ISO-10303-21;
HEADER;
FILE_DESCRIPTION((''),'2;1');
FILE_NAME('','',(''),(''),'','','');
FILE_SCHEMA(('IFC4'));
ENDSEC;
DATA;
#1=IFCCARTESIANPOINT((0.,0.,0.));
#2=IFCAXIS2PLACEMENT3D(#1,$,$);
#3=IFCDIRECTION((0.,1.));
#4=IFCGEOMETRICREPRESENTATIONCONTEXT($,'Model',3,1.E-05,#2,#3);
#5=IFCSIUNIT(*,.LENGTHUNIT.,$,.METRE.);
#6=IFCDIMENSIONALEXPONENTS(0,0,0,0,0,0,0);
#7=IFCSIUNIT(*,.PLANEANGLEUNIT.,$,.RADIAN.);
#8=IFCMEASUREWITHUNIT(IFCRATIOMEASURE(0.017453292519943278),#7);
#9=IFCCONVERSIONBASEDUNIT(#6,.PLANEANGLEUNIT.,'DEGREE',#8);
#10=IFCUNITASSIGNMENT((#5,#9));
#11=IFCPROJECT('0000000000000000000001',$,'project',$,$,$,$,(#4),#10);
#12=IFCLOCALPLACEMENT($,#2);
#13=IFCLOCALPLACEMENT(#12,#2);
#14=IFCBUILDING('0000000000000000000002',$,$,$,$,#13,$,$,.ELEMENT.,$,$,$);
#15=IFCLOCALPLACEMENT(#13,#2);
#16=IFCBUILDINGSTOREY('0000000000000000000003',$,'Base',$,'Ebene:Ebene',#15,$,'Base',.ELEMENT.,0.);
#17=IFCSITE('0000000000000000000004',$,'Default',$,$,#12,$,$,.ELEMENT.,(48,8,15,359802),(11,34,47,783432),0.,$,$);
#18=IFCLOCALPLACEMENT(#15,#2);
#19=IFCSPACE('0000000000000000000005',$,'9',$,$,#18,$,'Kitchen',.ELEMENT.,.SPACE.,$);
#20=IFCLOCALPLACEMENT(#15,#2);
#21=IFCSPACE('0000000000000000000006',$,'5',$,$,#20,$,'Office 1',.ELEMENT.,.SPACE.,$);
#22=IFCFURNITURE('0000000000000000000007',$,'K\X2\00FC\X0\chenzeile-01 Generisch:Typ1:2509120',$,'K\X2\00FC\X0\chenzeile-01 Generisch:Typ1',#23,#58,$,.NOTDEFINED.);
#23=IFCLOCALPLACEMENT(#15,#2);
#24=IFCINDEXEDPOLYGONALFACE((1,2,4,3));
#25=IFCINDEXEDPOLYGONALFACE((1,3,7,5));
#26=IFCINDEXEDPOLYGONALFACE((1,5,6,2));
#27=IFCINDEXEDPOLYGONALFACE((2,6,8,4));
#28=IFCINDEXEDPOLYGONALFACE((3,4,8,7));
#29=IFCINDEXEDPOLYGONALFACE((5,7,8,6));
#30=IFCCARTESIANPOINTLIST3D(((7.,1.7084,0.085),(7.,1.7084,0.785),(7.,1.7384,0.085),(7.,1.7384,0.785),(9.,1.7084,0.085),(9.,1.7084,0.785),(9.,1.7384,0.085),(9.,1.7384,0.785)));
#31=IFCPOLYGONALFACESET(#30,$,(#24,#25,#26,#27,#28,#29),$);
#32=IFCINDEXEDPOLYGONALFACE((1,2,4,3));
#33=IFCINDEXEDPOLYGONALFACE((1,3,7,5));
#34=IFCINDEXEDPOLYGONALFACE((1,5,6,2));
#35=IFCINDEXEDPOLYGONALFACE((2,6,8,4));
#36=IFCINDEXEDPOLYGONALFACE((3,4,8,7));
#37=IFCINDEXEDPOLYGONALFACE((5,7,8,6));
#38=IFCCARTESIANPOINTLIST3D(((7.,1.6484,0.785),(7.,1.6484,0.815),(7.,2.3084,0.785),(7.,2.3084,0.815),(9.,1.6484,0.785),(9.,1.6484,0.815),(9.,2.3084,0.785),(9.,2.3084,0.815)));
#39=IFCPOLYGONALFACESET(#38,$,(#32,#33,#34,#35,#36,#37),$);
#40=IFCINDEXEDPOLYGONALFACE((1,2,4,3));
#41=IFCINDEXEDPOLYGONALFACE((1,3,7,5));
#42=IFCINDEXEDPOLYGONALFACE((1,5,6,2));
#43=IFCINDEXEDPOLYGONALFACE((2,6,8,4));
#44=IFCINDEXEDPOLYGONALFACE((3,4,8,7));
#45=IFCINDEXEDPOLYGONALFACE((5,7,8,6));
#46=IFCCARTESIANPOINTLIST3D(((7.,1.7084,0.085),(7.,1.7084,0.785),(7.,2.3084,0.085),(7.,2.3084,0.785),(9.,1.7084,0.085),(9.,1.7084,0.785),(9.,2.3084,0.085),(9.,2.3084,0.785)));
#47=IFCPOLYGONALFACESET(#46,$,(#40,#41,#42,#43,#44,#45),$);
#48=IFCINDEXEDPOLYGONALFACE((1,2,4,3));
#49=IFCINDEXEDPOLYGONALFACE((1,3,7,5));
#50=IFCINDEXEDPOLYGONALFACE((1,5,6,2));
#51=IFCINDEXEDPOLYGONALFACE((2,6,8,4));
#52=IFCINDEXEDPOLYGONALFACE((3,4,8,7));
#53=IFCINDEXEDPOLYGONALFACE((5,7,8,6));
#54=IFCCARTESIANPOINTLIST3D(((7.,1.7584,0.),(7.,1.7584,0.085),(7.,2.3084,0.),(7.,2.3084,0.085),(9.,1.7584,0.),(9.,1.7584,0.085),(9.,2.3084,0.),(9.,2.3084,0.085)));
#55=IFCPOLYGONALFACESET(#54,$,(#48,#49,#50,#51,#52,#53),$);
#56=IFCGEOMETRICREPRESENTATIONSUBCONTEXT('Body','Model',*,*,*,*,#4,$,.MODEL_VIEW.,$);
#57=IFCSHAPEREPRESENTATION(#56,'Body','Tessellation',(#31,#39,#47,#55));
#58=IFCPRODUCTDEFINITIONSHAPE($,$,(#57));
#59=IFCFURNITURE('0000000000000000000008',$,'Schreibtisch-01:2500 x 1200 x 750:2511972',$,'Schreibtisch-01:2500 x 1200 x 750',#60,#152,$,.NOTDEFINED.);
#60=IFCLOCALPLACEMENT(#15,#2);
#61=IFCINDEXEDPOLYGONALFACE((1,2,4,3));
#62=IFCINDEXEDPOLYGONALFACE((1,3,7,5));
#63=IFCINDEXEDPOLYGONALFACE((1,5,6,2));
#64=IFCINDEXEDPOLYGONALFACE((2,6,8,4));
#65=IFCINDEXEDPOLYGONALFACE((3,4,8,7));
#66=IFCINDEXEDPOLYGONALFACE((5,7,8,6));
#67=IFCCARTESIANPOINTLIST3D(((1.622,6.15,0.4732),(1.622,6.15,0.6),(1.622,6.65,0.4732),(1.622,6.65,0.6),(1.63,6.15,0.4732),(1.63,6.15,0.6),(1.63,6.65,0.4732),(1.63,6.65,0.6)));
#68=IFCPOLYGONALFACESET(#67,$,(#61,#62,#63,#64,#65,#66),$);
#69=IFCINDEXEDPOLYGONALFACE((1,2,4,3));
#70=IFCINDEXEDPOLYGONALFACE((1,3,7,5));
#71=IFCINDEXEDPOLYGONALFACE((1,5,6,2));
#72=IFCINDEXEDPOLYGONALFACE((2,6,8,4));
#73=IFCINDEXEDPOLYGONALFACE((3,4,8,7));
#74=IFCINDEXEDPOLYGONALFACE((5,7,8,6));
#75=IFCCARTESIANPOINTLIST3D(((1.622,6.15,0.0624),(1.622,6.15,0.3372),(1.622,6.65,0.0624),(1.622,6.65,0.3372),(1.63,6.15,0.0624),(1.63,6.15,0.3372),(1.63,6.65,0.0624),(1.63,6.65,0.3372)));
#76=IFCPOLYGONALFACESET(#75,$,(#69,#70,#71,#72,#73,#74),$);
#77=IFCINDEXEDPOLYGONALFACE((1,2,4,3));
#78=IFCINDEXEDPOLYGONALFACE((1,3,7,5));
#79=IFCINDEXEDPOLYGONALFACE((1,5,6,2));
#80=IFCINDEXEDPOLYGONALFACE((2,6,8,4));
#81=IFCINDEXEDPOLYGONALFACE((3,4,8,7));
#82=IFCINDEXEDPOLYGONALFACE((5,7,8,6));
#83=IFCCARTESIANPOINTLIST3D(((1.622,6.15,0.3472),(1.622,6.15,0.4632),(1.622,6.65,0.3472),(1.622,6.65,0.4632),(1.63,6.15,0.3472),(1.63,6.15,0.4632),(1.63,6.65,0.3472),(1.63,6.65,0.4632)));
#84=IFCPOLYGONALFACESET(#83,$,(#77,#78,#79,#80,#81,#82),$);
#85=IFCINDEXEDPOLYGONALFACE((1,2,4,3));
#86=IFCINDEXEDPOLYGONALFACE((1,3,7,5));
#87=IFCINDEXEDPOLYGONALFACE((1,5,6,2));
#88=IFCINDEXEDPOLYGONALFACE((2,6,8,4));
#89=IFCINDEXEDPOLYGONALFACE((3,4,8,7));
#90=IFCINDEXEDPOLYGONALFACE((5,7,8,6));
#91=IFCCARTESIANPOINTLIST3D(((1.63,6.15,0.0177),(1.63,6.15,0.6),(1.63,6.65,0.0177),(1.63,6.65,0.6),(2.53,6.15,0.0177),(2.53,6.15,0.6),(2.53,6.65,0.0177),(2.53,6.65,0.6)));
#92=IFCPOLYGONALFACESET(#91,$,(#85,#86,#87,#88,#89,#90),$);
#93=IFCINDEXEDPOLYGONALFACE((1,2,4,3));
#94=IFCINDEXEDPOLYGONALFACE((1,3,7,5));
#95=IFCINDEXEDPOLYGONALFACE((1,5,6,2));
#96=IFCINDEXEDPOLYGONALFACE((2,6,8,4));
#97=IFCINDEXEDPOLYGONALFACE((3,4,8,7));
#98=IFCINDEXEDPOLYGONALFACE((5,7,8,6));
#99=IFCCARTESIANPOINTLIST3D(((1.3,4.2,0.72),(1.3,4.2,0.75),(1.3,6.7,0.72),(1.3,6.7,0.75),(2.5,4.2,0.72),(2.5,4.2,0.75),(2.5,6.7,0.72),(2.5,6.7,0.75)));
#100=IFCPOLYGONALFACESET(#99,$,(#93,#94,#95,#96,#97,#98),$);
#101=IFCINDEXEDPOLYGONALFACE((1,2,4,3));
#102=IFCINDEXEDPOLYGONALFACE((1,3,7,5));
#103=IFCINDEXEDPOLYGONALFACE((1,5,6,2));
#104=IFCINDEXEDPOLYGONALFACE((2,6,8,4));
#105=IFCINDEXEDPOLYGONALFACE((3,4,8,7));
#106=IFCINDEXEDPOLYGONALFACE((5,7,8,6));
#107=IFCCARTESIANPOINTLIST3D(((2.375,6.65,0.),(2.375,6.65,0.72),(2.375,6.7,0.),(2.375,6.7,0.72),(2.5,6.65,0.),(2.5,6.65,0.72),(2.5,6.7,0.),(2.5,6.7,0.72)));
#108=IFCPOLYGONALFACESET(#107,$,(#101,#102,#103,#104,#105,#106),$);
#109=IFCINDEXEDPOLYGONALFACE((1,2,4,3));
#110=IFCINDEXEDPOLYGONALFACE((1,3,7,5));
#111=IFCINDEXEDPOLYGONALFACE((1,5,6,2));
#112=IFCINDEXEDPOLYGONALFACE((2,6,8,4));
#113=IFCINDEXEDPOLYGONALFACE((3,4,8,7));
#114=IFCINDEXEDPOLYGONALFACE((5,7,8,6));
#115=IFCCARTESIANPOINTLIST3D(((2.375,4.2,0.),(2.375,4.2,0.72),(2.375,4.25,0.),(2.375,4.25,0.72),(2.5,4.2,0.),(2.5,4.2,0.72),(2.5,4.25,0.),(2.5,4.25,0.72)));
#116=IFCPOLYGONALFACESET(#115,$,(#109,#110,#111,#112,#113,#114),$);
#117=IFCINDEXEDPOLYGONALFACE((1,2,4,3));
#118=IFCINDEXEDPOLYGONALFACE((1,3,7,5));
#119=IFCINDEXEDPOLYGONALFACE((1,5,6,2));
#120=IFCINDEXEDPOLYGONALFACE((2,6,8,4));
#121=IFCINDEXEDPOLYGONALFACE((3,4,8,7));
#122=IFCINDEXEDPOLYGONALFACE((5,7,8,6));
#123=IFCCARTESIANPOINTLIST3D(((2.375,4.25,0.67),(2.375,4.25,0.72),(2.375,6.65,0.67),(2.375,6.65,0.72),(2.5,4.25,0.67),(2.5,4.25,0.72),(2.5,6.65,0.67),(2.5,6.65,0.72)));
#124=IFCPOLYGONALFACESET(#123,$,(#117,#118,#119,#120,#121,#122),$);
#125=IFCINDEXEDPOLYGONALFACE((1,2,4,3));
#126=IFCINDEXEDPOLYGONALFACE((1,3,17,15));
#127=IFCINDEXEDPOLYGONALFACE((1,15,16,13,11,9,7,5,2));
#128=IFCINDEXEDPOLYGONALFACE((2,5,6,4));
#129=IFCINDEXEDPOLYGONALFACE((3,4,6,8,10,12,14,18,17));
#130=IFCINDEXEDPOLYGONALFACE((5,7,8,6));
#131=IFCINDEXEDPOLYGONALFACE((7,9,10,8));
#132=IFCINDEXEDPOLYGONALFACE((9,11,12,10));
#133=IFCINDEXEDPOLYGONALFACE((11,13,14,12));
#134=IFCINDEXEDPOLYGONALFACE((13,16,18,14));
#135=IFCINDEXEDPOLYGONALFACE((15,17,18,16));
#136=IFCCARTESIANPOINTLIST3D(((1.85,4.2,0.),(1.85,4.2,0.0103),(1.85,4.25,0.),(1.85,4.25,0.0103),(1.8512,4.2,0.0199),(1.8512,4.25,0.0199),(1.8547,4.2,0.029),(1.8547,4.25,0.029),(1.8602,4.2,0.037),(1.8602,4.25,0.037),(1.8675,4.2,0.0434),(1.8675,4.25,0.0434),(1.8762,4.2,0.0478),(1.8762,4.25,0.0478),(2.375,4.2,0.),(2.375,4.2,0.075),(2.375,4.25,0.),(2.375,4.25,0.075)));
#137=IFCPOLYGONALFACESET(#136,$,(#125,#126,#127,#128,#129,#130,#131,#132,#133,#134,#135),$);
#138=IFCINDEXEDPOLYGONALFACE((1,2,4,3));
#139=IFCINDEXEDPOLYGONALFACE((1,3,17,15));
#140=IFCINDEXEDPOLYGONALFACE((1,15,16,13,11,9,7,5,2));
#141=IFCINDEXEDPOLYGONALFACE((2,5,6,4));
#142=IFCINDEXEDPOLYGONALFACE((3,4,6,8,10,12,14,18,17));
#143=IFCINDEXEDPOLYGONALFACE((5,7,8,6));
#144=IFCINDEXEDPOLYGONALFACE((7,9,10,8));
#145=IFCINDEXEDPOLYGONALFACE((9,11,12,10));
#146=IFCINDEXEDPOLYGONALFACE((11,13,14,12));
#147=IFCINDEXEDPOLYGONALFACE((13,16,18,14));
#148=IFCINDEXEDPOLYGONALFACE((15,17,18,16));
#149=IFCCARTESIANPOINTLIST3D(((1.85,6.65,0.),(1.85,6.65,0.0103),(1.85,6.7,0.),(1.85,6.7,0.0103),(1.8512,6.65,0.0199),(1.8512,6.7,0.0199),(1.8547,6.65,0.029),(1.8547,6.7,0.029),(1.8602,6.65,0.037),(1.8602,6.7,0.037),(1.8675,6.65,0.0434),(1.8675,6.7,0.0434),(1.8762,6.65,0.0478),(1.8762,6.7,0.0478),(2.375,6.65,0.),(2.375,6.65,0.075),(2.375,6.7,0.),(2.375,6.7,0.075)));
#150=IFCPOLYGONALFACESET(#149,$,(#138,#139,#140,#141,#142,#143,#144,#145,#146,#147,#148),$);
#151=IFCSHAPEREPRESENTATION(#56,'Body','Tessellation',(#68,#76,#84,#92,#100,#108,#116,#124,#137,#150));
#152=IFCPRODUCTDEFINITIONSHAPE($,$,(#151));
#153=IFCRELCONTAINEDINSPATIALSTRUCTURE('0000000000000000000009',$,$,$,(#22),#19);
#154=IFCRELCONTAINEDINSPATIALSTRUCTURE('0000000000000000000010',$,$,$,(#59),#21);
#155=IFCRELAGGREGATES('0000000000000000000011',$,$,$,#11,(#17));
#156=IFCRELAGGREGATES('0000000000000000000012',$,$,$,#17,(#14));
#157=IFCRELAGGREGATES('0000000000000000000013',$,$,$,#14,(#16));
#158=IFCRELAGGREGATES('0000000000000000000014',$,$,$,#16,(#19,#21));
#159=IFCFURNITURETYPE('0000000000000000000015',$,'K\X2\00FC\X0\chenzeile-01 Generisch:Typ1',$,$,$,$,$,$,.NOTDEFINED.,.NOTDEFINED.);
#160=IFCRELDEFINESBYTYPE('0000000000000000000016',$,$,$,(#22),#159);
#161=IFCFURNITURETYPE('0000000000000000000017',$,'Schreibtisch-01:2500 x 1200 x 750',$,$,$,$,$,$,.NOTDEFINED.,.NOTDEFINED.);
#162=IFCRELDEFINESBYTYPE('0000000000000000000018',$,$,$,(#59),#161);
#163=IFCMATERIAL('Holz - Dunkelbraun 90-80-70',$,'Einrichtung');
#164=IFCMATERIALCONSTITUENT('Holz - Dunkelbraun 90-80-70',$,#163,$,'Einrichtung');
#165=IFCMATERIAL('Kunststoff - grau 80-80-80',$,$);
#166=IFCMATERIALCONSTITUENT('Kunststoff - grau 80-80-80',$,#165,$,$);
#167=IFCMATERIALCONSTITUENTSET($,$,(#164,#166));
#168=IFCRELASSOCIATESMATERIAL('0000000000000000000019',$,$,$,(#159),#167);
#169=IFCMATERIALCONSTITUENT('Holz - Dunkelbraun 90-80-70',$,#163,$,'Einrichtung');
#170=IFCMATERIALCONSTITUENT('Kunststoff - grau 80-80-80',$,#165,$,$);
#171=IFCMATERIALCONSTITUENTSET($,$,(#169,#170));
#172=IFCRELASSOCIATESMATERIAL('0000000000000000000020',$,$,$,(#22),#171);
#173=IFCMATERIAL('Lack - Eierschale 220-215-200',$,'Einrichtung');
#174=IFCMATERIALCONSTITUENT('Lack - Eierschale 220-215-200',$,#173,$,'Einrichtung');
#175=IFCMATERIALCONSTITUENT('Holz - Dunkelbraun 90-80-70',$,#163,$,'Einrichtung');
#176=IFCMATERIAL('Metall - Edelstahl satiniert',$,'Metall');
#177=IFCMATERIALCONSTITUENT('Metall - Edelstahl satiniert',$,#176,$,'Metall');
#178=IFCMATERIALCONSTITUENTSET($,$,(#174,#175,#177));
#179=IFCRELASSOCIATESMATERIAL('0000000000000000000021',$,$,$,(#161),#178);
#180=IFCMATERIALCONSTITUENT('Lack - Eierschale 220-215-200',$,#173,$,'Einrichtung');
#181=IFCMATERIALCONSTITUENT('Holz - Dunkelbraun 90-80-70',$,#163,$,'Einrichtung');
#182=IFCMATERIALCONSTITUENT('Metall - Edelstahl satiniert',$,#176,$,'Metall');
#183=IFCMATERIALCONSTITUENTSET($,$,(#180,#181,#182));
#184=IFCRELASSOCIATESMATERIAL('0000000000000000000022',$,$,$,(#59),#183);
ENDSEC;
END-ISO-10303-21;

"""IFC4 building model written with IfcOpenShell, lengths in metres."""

from ifc_helpers import new_model, entity, si_unit, converted_unit, direction, frame, origin, place, context, subcontext, project, spatial, line, arc, indexed_curve, outline, extrude, source, transform, mapped, material, constituent, constituent_set, type_object, type_shapes, element, save


model = new_model("IFC4")

# Units and contexts
model_context = context("Model", 3, precision=1e-05, world=origin(), true_north=direction((0.0, 1.0)))
body_context = subcontext(model_context, "Body", "Model", "MODEL_VIEW")
ifc_project = project(units=[si_unit("LENGTHUNIT", "METRE"), converted_unit("PLANEANGLEUNIT", "DEGREE", entity("IfcRatioMeasure", 0.017453292519943278), si_unit("PLANEANGLEUNIT", "RADIAN"), dimensions=[0, 0, 0, 0, 0, 0, 0])], contexts=[model_context])

# Site, building, storey, space
site_placement = place(None, origin())
site = spatial("IfcSite", under=ifc_project, at=site_placement, Name="Default", CompositionType="ELEMENT", RefLatitude=(48, 8, 15, 359802), RefLongitude=(11, 34, 47, 783432), RefElevation=0.0)
building_placement = place(site_placement, origin())
building = spatial("IfcBuilding", under=site, at=building_placement, CompositionType="ELEMENT")
storey_placement = place(building_placement, origin())
storey = spatial("IfcBuildingStorey", under=building, at=storey_placement, Name="Base", ObjectType="Ebene:Ebene", LongName="Base", CompositionType="ELEMENT", Elevation=0.0)
space_1_placement = place(storey_placement, origin())
space_1 = spatial("IfcSpace", under=storey, at=space_1_placement, Name="9", LongName="Kitchen", CompositionType="ELEMENT", PredefinedType="SPACE")

# Furniture
ifc_material_1 = material(Name="Holz - Dunkelbraun 90-80-70", Category="Einrichtung")
ifc_constituent_1 = constituent(ifc_material_1, Name="Holz - Dunkelbraun 90-80-70", Category="Einrichtung")
ifc_material_2 = material(Name="Kunststoff - grau 80-80-80")
ifc_constituent_2 = constituent(ifc_material_2, Name="Kunststoff - grau 80-80-80")
ifc_constituent_set_1 = constituent_set(constituents=[ifc_constituent_1, ifc_constituent_2])
ifc_constituent_3 = constituent(ifc_material_1, Name="Holz - Dunkelbraun 90-80-70", Category="Einrichtung")
ifc_constituent_4 = constituent(ifc_material_2, Name="Kunststoff - grau 80-80-80")
ifc_constituent_set_2 = constituent_set(constituents=[ifc_constituent_3, ifc_constituent_4])
furniture_type_1 = type_object("IfcFurnitureType", Name="Küchenzeile-01 Generisch:Typ1", AssemblyPlace="NOTDEFINED", PredefinedType="NOTDEFINED", material=ifc_constituent_set_2)
shared_shape_1 = source(origin(), body_context, "Body", "SweptSolid", [
    extrude(outline(indexed_curve([(-1.0, -0.015), (1.0, -0.015), (1.0, 0.015), (-1.0, 0.015), (-1.0, -0.015)], self_intersect=False)), frame((-0.72, -0.285, 0.085)), (0.0, 0.0, 1.0), 0.7),
    extrude(outline(indexed_curve([(-1.0, -0.33), (1.0, -0.33), (1.0, 0.33), (-1.0, 0.33), (-1.0, -0.33)], self_intersect=False)), frame((-0.72, -0.03, 0.785)), (0.0, 0.0, 1.0), 0.03),
    extrude(outline(indexed_curve([(-1.0, -0.3), (1.0, -0.3), (1.0, 0.3), (-1.0, 0.3), (-1.0, -0.3)], self_intersect=False)), frame((-0.72, 0.0, 0.085)), (0.0, 0.0, 1.0), 0.7),
    extrude(outline(indexed_curve([(-1.0, -0.275), (1.0, -0.275), (1.0, 0.275), (-1.0, 0.275), (-1.0, -0.275)], self_intersect=False)), frame((-0.72, 0.025, 0.0)), (0.0, 0.0, 1.0), 0.085),
])
type_shapes(furniture_type_1, [shared_shape_1])
furniture_1_placement = place(space_1_placement, frame((8.72, 2.0084, 0.0)))
element("IfcFurniture", 1, at=furniture_1_placement, inside=space_1, type_object=furniture_type_1, material=ifc_constituent_set_1, Name="Küchenzeile-01 Generisch:Typ1:2509120", ObjectType="Küchenzeile-01 Generisch:Typ1", PredefinedType="NOTDEFINED", context=body_context, shape_type="MappedRepresentation", body=[
    mapped(shared_shape_1, transform((0.0, 0.0, 0.0), scale=1.0)),
])

# Shared definitions
space_2_placement = place(storey_placement, origin())
space_2 = spatial("IfcSpace", under=storey, at=space_2_placement, Name="5", LongName="Office 1", CompositionType="ELEMENT", PredefinedType="SPACE")

# Furniture
ifc_material_3 = material(Name="Lack - Eierschale 220-215-200", Category="Einrichtung")
ifc_constituent_5 = constituent(ifc_material_3, Name="Lack - Eierschale 220-215-200", Category="Einrichtung")
ifc_constituent_6 = constituent(ifc_material_1, Name="Holz - Dunkelbraun 90-80-70", Category="Einrichtung")
ifc_material_4 = material(Name="Metall - Edelstahl satiniert", Category="Metall")
ifc_constituent_7 = constituent(ifc_material_4, Name="Metall - Edelstahl satiniert", Category="Metall")
ifc_constituent_set_3 = constituent_set(constituents=[ifc_constituent_5, ifc_constituent_6, ifc_constituent_7])
ifc_constituent_8 = constituent(ifc_material_3, Name="Lack - Eierschale 220-215-200", Category="Einrichtung")
ifc_constituent_9 = constituent(ifc_material_1, Name="Holz - Dunkelbraun 90-80-70", Category="Einrichtung")
ifc_constituent_10 = constituent(ifc_material_4, Name="Metall - Edelstahl satiniert", Category="Metall")
ifc_constituent_set_4 = constituent_set(constituents=[ifc_constituent_8, ifc_constituent_9, ifc_constituent_10])
furniture_type_2 = type_object("IfcFurnitureType", Name="Schreibtisch-01:2500 x 1200 x 750", AssemblyPlace="NOTDEFINED", PredefinedType="NOTDEFINED", material=ifc_constituent_set_4)
shared_shape_2 = source(origin(), body_context, "Body", "SweptSolid", [
    extrude(outline(indexed_curve([(-0.004, -0.25), (0.004, -0.25), (0.004, 0.25), (-0.004, 0.25), (-0.004, -0.25)], self_intersect=False)), frame((0.95, 0.574, 0.4732), z_axis=(0.0, 0.0, 1.0), x_axis=(0.0, 1.0, 0.0)), (0.0, 0.0, 1.0), 0.1268),
    extrude(outline(indexed_curve([(-0.004, -0.25), (0.004, -0.25), (0.004, 0.25), (-0.004, 0.25), (-0.004, -0.25)], self_intersect=False)), frame((0.95, 0.574, 0.0624), z_axis=(0.0, 0.0, 1.0), x_axis=(0.0, 1.0, 0.0)), (0.0, 0.0, 1.0), 0.2748),
    extrude(outline(indexed_curve([(-0.004, -0.25), (0.004, -0.25), (0.004, 0.25), (-0.004, 0.25), (-0.004, -0.25)], self_intersect=False)), frame((0.95, 0.574, 0.3472), z_axis=(0.0, 0.0, 1.0), x_axis=(0.0, 1.0, 0.0)), (0.0, 0.0, 1.0), 0.116),
    extrude(outline(indexed_curve([(-0.25, -0.45), (0.25, -0.45), (0.25, 0.45), (-0.25, 0.45), (-0.25, -0.45)], self_intersect=False)), frame((0.95, 0.12, 0.0177)), (0.0, 0.0, 1.0), 0.5823),
    extrude(outline(indexed_curve([(-1.25, -0.6), (1.25, -0.6), (1.25, 0.6), (-1.25, 0.6), (-1.25, -0.6)], self_intersect=False)), frame((0.0, 0.3, 0.72), z_axis=(0.0, 0.0, 1.0), x_axis=(-1.0, 0.0, 0.0)), (0.0, 0.0, 1.0), 0.03),
    extrude(outline(indexed_curve([(-0.025, -0.0625), (0.025, -0.0625), (0.025, 0.0625), (-0.025, 0.0625), (-0.025, -0.0625)], self_intersect=False)), frame((1.225, -0.2375, 0.0)), (0.0, 0.0, 1.0), 0.72),
    extrude(outline(indexed_curve([(-0.0625, -0.025), (0.0625, -0.025), (0.0625, 0.025), (-0.0625, 0.025), (-0.0625, -0.025)], self_intersect=False)), frame((-1.225, -0.2375, 0.0), z_axis=(0.0, 0.0, 1.0), x_axis=(0.0, 1.0, 0.0)), (0.0, 0.0, 1.0), 0.72),
    extrude(outline(indexed_curve([(-0.0625, -1.2), (0.0625, -1.2), (0.0625, 1.2), (-0.0625, 1.2), (-0.0625, -1.2)], self_intersect=False)), frame((0.0, -0.2375, 0.67), z_axis=(0.0, 0.0, 1.0), x_axis=(0.0, 1.0, 0.0)), (0.0, 0.0, 1.0), 0.05),
    extrude(outline(indexed_curve([(-0.0266, -0.2152), (-0.0163, -0.2152), (0.0065, -0.208), (0.0212, -0.189), (0.0484, 0.3098), (-0.0266, 0.3098)], segments=[line(1, 2), arc(2, 3, 4), line(4, 5, 6, 1)], self_intersect=False)), frame((-1.25, 0.1348, 0.0266), z_axis=(1.0, 0.0, 0.0), x_axis=(0.0, 0.0, 1.0)), (0.0, 0.0, 1.0), 0.05),
    extrude(outline(indexed_curve([(-0.0266, -0.2152), (-0.0163, -0.2152), (0.0065, -0.208), (0.0212, -0.189), (0.0484, 0.3098), (-0.0266, 0.3098)], segments=[line(1, 2), arc(2, 3, 4), line(4, 5, 6, 1)], self_intersect=False)), frame((1.2, 0.1348, 0.0266), z_axis=(1.0, 0.0, 0.0), x_axis=(0.0, 0.0, 1.0)), (0.0, 0.0, 1.0), 0.05),
])
type_shapes(furniture_type_2, [shared_shape_2])
furniture_2_placement = place(space_2_placement, frame((2.2, 5.45, 0.0), z_axis=(0.0, 0.0, 1.0), x_axis=(0.0, 1.0, 0.0)))
element("IfcFurniture", 2, at=furniture_2_placement, inside=space_2, type_object=furniture_type_2, material=ifc_constituent_set_3, Name="Schreibtisch-01:2500 x 1200 x 750:2511972", ObjectType="Schreibtisch-01:2500 x 1200 x 750", PredefinedType="NOTDEFINED", context=body_context, shape_type="MappedRepresentation", body=[
    mapped(shared_shape_2, transform((0.0, 0.0, 0.0), scale=1.0)),
])

save(model, "model.ifc")
